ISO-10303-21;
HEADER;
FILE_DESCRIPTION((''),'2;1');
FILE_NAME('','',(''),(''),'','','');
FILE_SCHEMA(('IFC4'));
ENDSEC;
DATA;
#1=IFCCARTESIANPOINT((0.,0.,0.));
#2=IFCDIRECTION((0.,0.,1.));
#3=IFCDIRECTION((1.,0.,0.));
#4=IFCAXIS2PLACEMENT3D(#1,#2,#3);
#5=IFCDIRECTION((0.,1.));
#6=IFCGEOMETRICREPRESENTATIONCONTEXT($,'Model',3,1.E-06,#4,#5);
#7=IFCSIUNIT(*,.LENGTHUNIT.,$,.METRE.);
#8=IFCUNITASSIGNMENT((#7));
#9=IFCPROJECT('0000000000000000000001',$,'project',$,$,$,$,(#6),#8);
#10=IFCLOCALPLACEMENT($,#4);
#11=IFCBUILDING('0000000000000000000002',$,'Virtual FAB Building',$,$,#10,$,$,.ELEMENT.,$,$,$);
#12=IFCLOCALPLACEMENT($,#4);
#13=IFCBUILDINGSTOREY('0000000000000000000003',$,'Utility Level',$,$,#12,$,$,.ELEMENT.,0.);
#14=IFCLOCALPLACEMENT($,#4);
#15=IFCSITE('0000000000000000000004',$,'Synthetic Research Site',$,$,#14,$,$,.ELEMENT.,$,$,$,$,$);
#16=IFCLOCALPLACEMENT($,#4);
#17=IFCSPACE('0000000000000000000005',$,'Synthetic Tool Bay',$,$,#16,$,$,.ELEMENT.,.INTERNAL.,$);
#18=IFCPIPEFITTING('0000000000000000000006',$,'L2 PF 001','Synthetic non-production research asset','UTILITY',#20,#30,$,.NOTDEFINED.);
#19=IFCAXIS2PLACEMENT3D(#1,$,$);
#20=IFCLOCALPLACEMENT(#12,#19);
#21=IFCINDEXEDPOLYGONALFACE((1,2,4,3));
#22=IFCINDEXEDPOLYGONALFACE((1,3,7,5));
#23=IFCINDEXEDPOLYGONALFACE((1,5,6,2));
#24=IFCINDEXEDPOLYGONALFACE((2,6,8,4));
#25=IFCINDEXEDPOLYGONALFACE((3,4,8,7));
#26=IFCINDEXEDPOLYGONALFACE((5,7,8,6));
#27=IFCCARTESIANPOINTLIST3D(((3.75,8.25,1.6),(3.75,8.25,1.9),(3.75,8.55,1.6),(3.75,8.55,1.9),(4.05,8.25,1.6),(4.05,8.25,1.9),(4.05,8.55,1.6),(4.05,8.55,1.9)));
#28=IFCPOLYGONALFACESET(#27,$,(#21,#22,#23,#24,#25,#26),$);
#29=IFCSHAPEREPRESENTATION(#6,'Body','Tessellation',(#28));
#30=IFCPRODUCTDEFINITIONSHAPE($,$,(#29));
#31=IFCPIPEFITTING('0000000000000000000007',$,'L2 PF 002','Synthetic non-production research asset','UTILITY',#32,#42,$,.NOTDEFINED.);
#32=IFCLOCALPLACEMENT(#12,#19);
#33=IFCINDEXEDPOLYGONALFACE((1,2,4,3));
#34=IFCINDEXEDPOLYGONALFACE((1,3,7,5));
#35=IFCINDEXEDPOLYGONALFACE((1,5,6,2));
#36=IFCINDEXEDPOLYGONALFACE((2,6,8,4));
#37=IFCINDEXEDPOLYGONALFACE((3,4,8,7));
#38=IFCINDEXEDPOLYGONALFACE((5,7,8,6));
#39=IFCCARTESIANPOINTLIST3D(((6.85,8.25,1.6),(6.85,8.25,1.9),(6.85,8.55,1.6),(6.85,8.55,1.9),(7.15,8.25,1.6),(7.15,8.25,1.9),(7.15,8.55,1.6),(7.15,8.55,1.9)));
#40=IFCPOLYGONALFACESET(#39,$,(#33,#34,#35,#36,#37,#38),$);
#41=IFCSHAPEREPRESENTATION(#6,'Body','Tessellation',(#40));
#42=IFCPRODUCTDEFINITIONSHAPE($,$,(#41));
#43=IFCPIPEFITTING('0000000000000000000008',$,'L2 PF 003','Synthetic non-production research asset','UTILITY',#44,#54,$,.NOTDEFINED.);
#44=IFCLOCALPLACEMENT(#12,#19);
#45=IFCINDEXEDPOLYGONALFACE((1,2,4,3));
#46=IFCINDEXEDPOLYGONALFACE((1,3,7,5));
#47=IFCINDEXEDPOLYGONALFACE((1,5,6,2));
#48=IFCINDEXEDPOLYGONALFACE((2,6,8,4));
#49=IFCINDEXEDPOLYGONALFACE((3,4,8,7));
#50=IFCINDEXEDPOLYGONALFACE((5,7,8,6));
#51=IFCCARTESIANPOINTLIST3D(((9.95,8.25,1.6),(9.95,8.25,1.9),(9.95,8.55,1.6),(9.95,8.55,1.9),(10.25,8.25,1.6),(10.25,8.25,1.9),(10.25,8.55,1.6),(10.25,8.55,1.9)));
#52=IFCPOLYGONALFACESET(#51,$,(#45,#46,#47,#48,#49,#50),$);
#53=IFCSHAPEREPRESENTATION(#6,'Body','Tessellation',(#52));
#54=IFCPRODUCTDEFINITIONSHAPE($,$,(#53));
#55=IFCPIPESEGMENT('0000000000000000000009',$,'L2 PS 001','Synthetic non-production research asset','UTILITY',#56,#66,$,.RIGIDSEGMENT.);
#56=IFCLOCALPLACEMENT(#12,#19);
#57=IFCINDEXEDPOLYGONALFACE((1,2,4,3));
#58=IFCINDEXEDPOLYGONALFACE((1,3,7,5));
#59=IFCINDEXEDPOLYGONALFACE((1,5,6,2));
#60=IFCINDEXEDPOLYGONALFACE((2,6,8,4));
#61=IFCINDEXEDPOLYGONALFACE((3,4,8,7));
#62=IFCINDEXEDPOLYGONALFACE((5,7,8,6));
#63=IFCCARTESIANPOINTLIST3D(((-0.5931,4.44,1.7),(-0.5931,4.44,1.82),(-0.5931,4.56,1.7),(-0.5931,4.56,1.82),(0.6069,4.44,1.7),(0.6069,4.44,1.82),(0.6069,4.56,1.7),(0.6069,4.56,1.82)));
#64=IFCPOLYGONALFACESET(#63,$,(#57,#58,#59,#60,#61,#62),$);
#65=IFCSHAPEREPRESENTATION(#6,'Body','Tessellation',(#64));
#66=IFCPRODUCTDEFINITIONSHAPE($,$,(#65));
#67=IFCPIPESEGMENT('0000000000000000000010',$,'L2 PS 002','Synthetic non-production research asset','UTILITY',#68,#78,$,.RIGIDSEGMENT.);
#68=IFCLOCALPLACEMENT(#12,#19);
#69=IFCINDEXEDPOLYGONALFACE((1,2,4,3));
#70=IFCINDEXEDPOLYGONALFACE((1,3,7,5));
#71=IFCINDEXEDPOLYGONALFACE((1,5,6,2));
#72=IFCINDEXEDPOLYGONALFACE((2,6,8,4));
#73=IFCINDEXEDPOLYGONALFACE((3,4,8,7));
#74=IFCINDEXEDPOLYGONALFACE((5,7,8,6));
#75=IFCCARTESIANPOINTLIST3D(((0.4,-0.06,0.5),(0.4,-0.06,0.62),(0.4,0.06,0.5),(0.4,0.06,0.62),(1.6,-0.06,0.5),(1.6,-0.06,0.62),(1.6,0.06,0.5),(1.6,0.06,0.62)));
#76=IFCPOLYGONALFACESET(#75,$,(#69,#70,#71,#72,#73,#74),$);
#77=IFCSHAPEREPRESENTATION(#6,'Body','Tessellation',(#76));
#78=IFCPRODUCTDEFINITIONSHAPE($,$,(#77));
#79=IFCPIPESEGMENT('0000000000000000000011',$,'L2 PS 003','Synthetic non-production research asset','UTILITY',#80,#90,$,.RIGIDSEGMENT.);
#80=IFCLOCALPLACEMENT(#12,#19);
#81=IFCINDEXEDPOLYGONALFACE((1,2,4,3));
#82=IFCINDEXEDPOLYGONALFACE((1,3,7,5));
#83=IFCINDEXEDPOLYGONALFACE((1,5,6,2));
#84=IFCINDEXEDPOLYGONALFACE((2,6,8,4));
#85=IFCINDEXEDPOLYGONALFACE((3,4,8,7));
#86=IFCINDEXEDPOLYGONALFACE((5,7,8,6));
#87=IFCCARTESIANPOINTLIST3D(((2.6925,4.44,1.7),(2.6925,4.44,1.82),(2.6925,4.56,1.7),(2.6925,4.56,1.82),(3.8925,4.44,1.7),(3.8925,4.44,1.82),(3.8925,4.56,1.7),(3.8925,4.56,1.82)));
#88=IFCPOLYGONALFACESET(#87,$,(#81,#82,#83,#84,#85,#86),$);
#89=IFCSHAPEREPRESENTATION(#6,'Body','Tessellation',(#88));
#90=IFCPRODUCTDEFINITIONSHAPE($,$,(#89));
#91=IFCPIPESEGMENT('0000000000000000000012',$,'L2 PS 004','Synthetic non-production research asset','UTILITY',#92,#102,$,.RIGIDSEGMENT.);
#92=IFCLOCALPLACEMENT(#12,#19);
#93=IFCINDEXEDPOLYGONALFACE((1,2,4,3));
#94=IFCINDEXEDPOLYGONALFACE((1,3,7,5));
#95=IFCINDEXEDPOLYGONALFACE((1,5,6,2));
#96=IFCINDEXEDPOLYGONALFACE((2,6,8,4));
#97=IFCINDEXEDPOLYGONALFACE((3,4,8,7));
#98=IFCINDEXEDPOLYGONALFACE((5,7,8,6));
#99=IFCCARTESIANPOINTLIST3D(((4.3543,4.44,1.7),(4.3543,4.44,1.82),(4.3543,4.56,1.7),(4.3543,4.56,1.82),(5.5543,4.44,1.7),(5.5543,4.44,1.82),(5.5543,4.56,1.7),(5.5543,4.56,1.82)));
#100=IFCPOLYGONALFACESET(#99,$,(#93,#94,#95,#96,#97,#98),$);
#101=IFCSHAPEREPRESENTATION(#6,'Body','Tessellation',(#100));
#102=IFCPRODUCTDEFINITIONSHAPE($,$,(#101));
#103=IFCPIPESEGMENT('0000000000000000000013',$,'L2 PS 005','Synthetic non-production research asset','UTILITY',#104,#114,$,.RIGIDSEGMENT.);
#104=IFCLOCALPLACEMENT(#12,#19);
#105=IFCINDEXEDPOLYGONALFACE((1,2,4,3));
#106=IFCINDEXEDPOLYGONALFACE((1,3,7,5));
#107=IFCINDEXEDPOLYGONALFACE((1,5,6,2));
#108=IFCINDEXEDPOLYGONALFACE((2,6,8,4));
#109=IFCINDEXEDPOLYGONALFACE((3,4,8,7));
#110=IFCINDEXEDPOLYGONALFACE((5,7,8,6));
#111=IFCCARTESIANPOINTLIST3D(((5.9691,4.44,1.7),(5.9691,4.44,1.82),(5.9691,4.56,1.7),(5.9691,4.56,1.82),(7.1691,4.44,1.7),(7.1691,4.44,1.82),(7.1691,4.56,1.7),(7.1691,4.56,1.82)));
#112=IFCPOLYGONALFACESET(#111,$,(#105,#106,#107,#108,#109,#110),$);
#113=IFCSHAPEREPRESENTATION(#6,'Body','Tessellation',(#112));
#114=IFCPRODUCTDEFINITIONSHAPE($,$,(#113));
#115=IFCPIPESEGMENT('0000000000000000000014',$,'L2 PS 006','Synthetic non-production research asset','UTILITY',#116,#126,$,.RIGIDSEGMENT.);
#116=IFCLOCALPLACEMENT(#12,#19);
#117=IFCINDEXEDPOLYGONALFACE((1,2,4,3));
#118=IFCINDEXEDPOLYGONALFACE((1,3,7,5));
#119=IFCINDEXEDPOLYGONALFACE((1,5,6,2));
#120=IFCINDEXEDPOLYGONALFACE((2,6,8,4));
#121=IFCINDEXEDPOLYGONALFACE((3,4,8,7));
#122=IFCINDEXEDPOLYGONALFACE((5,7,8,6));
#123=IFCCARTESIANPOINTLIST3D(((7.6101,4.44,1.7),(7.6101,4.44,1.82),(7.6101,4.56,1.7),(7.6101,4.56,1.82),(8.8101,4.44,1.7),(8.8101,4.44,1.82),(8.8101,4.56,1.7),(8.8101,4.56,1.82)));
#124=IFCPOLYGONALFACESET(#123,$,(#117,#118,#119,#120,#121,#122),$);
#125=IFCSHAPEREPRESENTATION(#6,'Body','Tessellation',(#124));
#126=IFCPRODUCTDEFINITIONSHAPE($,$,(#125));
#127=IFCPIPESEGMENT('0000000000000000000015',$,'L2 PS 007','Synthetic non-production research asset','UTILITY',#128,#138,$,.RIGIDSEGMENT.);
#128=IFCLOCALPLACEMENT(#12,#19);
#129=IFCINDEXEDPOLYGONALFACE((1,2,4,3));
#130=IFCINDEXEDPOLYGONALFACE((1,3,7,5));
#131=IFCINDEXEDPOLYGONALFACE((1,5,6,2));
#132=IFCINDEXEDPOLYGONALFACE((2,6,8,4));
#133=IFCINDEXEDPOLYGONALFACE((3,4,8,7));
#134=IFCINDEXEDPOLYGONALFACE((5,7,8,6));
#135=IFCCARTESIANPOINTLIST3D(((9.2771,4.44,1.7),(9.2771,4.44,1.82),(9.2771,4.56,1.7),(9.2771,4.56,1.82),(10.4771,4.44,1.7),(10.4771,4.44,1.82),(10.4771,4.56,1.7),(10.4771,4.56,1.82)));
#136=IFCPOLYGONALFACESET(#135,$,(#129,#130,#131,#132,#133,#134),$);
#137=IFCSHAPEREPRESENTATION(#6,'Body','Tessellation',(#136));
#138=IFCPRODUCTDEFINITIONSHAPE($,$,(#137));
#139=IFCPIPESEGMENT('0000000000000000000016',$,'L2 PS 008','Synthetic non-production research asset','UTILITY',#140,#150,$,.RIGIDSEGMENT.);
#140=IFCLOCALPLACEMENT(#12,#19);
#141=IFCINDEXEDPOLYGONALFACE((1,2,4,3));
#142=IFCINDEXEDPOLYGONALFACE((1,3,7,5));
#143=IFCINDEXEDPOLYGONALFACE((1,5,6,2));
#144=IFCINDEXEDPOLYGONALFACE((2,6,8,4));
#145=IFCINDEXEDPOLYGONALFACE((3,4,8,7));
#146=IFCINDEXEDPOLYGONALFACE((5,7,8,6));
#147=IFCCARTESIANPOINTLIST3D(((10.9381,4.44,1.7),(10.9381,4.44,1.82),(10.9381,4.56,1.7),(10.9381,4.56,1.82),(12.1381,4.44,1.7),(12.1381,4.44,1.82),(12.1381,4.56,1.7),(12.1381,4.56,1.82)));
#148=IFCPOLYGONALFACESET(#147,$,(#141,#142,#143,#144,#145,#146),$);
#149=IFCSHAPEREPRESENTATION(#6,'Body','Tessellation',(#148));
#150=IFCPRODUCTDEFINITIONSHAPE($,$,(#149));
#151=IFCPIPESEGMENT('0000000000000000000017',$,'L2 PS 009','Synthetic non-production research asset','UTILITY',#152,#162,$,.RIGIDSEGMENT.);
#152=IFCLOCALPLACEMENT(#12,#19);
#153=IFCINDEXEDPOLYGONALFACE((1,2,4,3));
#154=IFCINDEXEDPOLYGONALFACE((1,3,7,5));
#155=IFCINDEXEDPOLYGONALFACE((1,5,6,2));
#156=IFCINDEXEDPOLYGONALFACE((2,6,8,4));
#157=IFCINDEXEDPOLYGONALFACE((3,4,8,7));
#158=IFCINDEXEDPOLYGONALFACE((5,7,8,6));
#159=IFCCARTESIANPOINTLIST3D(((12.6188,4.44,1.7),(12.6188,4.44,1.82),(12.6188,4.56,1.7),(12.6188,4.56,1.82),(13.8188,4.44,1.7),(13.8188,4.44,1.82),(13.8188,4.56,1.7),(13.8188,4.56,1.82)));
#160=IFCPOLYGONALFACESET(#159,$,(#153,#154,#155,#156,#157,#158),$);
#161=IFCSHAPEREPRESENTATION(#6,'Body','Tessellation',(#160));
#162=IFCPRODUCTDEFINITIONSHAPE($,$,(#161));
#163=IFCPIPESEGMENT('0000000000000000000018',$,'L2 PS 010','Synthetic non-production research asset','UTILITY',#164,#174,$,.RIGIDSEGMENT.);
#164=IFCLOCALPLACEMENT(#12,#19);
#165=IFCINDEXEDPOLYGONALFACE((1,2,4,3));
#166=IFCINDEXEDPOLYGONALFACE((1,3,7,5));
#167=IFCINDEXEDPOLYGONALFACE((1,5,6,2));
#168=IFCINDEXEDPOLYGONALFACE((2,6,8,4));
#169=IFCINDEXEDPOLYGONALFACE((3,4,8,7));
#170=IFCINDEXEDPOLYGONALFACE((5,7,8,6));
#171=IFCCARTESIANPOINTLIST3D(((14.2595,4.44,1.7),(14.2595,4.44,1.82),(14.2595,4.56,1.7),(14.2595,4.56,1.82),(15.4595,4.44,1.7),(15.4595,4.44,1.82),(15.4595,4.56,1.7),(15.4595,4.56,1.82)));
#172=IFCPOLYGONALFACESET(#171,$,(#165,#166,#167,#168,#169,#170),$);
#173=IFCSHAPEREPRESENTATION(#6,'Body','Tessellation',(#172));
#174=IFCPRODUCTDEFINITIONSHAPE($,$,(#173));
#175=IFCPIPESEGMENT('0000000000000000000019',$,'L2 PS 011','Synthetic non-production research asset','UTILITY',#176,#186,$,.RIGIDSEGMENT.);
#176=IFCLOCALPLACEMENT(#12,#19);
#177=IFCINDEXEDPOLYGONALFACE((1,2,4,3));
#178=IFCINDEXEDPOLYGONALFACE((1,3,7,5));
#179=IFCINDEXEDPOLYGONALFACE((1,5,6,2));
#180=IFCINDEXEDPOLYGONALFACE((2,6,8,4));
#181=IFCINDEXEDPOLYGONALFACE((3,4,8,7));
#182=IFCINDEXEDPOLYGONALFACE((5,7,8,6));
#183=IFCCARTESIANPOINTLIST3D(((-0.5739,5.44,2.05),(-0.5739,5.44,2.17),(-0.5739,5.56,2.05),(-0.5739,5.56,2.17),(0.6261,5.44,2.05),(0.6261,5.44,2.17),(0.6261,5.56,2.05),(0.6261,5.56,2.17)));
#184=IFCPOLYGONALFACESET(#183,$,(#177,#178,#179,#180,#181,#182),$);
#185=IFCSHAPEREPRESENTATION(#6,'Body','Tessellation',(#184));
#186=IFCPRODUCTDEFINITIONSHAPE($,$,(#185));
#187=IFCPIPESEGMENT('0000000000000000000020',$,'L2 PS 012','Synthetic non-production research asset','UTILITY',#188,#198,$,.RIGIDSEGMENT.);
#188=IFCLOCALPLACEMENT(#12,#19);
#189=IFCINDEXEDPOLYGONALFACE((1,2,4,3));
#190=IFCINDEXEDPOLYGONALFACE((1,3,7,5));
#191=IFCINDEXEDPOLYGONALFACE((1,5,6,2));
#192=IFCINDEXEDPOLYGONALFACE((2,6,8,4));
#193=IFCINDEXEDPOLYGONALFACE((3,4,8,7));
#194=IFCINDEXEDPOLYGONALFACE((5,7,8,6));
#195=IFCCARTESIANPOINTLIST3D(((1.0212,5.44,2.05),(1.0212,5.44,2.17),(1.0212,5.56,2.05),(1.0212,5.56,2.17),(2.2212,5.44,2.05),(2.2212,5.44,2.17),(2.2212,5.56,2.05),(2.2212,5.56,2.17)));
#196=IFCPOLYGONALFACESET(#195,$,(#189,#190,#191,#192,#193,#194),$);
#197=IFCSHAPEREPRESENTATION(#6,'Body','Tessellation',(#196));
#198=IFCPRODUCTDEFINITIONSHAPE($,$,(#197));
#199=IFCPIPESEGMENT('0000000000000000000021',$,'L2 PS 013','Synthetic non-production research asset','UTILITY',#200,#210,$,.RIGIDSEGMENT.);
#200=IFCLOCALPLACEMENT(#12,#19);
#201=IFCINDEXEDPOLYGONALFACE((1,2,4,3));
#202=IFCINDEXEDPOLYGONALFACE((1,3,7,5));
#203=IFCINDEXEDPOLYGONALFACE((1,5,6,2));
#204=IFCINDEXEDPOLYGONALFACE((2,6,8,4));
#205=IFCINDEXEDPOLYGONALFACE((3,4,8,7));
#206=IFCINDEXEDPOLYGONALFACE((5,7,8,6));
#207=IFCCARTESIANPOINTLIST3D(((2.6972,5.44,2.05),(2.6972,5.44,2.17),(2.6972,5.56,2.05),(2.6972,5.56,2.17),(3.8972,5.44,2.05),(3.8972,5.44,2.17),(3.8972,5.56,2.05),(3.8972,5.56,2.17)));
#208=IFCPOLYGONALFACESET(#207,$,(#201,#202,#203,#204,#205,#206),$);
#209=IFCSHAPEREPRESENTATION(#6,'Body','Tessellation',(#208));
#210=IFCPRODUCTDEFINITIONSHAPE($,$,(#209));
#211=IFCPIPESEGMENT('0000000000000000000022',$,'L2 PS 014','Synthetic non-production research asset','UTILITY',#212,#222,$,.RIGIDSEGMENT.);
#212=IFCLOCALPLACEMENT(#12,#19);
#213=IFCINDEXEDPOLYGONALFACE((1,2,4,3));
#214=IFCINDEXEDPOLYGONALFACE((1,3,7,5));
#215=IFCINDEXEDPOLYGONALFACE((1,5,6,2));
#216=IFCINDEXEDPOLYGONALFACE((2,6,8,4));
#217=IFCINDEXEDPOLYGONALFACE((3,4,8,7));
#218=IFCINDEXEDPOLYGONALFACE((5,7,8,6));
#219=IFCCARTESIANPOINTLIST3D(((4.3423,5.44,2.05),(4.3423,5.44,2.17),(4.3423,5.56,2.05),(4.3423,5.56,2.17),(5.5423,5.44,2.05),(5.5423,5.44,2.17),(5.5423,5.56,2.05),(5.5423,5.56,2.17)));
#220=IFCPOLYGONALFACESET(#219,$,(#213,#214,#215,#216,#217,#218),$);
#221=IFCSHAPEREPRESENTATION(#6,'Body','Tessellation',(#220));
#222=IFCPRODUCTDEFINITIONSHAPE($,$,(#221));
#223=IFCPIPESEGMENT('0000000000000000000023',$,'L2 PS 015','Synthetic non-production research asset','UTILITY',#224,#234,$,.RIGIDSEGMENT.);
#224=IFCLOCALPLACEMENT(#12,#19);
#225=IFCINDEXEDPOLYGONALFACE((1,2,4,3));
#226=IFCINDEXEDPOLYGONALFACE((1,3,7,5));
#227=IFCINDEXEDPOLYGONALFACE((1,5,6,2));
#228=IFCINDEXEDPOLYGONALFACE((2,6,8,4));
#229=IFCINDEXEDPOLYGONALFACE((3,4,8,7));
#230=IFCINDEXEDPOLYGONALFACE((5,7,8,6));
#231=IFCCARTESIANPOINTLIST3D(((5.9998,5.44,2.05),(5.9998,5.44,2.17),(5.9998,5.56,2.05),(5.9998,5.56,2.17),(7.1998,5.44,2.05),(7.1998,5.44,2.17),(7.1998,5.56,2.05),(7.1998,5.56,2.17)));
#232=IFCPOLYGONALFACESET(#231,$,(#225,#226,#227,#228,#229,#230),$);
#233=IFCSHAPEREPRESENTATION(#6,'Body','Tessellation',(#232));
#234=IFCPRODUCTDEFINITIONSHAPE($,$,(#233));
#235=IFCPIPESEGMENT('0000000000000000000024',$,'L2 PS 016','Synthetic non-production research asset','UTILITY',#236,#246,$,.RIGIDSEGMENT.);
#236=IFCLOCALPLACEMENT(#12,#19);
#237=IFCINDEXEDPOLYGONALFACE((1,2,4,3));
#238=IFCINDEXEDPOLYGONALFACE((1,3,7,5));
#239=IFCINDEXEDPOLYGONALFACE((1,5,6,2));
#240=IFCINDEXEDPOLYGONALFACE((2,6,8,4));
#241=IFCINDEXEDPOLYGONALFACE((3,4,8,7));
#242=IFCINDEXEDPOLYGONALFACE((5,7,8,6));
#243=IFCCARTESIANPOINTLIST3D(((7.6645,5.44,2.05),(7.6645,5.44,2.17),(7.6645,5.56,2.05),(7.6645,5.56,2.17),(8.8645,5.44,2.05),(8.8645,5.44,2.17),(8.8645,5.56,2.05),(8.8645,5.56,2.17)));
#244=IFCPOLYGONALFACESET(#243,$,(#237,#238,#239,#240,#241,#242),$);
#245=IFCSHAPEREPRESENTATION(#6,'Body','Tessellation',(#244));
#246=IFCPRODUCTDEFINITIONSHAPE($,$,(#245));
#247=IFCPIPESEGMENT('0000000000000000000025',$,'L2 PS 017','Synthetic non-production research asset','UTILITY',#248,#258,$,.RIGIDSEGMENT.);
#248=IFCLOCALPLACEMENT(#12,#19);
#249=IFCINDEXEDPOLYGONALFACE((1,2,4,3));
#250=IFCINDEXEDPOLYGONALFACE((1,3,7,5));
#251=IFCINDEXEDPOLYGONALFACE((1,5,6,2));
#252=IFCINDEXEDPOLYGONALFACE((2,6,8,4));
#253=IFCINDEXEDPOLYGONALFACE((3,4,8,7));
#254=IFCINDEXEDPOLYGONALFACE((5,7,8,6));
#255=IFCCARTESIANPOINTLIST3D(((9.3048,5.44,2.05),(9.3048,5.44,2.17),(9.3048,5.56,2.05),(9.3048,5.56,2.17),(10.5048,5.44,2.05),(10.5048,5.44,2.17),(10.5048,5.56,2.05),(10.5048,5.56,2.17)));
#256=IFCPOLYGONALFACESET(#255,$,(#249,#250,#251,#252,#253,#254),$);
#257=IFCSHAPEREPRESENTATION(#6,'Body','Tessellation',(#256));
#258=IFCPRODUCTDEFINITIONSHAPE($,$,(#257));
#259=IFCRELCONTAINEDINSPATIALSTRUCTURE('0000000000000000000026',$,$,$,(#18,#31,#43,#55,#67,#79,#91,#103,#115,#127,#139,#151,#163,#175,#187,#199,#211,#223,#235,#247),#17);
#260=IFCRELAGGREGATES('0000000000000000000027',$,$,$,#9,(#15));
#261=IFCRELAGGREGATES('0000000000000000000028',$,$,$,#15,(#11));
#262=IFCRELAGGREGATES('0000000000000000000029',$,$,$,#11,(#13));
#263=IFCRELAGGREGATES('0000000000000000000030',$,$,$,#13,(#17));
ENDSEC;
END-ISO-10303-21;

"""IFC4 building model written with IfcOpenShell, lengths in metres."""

from ifc_helpers import new_model, si_unit, direction, frame, origin_with_axes, origin_2d_with_axis, place, context, project, spatial, rectangle, extrude, element, save


model = new_model("IFC4")

# Units and contexts
model_context = context("Model", 3, precision=1e-06, world=origin_with_axes(), true_north=direction((0.0, 1.0)))
ifc_project = project(units=[si_unit("LENGTHUNIT", "METRE")], contexts=[model_context])

# Site, building, storey, space
site_placement = place(None, origin_with_axes())
site = spatial("IfcSite", under=ifc_project, at=site_placement, Name="Synthetic Research Site", CompositionType="ELEMENT")
building_placement = place(None, origin_with_axes())
building = spatial("IfcBuilding", under=site, at=building_placement, Name="Virtual FAB Building", CompositionType="ELEMENT")
storey_placement = place(None, origin_with_axes())
storey = spatial("IfcBuildingStorey", under=building, at=storey_placement, Name="Utility Level", CompositionType="ELEMENT", Elevation=0.0)
space_placement = place(None, origin_with_axes())
space = spatial("IfcSpace", under=storey, at=space_placement, Name="Synthetic Tool Bay", CompositionType="ELEMENT", PredefinedType="INTERNAL")

# Pipe fittings
for number, where, z_axis, x_axis, name in (
    (1, (3.9, 8.4, 1.6), (0.0, 0.0, 1.0), (1.0, 0.0, 0.0), "L2 PF 001"),
    (2, (7.0, 8.4, 1.6), (0.0, 0.0, 1.0), (1.0, 0.0, 0.0), "L2 PF 002"),
    (3, (10.1, 8.4, 1.6), (0.0, 0.0, 1.0), (1.0, 0.0, 0.0), "L2 PF 003"),
):
    element("IfcPipeFitting", number, at=place(None, frame(where, z_axis=z_axis, x_axis=x_axis)), inside=space, Name=name, Description="Synthetic non-production research asset", ObjectType="UTILITY", PredefinedType="NOTDEFINED", context=model_context, shape_type="SweptSolid", body=[
        extrude(rectangle(XDim=0.3, YDim=0.3, at=origin_2d_with_axis()), origin_with_axes(), (0.0, 0.0, 1.0), 0.3),
    ])

# Pipe segments
for number, where, z_axis, x_axis, name in (
    (4, (0.0069, 4.5, 1.7), (0.0, 0.0, 1.0), (1.0, 0.0, 0.0), "L2 PS 001"),
    (5, (1.0, 0.0, 0.5), (0.0, 0.0, 1.0), (1.0, 0.0, 0.0), "L2 PS 002"),
    (6, (3.2925, 4.5, 1.7), (0.0, 0.0, 1.0), (1.0, 0.0, 0.0), "L2 PS 003"),
    (7, (4.9543, 4.5, 1.7), (0.0, 0.0, 1.0), (1.0, 0.0, 0.0), "L2 PS 004"),
    (8, (6.5691, 4.5, 1.7), (0.0, 0.0, 1.0), (1.0, 0.0, 0.0), "L2 PS 005"),
    (9, (8.2101, 4.5, 1.7), (0.0, 0.0, 1.0), (1.0, 0.0, 0.0), "L2 PS 006"),
    (10, (9.8771, 4.5, 1.7), (0.0, 0.0, 1.0), (1.0, 0.0, 0.0), "L2 PS 007"),
    (11, (11.5381, 4.5, 1.7), (0.0, 0.0, 1.0), (1.0, 0.0, 0.0), "L2 PS 008"),
    (12, (13.2188, 4.5, 1.7), (0.0, 0.0, 1.0), (1.0, 0.0, 0.0), "L2 PS 009"),
    (13, (14.8595, 4.5, 1.7), (0.0, 0.0, 1.0), (1.0, 0.0, 0.0), "L2 PS 010"),
    (14, (0.0261, 5.5, 2.05), (0.0, 0.0, 1.0), (1.0, 0.0, 0.0), "L2 PS 011"),
    (15, (1.6212, 5.5, 2.05), (0.0, 0.0, 1.0), (1.0, 0.0, 0.0), "L2 PS 012"),
    (16, (3.2972, 5.5, 2.05), (0.0, 0.0, 1.0), (1.0, 0.0, 0.0), "L2 PS 013"),
    (17, (4.9423, 5.5, 2.05), (0.0, 0.0, 1.0), (1.0, 0.0, 0.0), "L2 PS 014"),
    (18, (6.5998, 5.5, 2.05), (0.0, 0.0, 1.0), (1.0, 0.0, 0.0), "L2 PS 015"),
    (19, (8.2645, 5.5, 2.05), (0.0, 0.0, 1.0), (1.0, 0.0, 0.0), "L2 PS 016"),
    (20, (9.9048, 5.5, 2.05), (0.0, 0.0, 1.0), (1.0, 0.0, 0.0), "L2 PS 017"),
):
    element("IfcPipeSegment", number, at=place(None, frame(where, z_axis=z_axis, x_axis=x_axis)), inside=space, Name=name, Description="Synthetic non-production research asset", ObjectType="UTILITY", PredefinedType="RIGIDSEGMENT", context=model_context, shape_type="SweptSolid", body=[
        extrude(rectangle(XDim=1.2, YDim=0.12, at=origin_2d_with_axis()), origin_with_axes(), (0.0, 0.0, 1.0), 0.12),
    ])

save(model, "model.ifc")
